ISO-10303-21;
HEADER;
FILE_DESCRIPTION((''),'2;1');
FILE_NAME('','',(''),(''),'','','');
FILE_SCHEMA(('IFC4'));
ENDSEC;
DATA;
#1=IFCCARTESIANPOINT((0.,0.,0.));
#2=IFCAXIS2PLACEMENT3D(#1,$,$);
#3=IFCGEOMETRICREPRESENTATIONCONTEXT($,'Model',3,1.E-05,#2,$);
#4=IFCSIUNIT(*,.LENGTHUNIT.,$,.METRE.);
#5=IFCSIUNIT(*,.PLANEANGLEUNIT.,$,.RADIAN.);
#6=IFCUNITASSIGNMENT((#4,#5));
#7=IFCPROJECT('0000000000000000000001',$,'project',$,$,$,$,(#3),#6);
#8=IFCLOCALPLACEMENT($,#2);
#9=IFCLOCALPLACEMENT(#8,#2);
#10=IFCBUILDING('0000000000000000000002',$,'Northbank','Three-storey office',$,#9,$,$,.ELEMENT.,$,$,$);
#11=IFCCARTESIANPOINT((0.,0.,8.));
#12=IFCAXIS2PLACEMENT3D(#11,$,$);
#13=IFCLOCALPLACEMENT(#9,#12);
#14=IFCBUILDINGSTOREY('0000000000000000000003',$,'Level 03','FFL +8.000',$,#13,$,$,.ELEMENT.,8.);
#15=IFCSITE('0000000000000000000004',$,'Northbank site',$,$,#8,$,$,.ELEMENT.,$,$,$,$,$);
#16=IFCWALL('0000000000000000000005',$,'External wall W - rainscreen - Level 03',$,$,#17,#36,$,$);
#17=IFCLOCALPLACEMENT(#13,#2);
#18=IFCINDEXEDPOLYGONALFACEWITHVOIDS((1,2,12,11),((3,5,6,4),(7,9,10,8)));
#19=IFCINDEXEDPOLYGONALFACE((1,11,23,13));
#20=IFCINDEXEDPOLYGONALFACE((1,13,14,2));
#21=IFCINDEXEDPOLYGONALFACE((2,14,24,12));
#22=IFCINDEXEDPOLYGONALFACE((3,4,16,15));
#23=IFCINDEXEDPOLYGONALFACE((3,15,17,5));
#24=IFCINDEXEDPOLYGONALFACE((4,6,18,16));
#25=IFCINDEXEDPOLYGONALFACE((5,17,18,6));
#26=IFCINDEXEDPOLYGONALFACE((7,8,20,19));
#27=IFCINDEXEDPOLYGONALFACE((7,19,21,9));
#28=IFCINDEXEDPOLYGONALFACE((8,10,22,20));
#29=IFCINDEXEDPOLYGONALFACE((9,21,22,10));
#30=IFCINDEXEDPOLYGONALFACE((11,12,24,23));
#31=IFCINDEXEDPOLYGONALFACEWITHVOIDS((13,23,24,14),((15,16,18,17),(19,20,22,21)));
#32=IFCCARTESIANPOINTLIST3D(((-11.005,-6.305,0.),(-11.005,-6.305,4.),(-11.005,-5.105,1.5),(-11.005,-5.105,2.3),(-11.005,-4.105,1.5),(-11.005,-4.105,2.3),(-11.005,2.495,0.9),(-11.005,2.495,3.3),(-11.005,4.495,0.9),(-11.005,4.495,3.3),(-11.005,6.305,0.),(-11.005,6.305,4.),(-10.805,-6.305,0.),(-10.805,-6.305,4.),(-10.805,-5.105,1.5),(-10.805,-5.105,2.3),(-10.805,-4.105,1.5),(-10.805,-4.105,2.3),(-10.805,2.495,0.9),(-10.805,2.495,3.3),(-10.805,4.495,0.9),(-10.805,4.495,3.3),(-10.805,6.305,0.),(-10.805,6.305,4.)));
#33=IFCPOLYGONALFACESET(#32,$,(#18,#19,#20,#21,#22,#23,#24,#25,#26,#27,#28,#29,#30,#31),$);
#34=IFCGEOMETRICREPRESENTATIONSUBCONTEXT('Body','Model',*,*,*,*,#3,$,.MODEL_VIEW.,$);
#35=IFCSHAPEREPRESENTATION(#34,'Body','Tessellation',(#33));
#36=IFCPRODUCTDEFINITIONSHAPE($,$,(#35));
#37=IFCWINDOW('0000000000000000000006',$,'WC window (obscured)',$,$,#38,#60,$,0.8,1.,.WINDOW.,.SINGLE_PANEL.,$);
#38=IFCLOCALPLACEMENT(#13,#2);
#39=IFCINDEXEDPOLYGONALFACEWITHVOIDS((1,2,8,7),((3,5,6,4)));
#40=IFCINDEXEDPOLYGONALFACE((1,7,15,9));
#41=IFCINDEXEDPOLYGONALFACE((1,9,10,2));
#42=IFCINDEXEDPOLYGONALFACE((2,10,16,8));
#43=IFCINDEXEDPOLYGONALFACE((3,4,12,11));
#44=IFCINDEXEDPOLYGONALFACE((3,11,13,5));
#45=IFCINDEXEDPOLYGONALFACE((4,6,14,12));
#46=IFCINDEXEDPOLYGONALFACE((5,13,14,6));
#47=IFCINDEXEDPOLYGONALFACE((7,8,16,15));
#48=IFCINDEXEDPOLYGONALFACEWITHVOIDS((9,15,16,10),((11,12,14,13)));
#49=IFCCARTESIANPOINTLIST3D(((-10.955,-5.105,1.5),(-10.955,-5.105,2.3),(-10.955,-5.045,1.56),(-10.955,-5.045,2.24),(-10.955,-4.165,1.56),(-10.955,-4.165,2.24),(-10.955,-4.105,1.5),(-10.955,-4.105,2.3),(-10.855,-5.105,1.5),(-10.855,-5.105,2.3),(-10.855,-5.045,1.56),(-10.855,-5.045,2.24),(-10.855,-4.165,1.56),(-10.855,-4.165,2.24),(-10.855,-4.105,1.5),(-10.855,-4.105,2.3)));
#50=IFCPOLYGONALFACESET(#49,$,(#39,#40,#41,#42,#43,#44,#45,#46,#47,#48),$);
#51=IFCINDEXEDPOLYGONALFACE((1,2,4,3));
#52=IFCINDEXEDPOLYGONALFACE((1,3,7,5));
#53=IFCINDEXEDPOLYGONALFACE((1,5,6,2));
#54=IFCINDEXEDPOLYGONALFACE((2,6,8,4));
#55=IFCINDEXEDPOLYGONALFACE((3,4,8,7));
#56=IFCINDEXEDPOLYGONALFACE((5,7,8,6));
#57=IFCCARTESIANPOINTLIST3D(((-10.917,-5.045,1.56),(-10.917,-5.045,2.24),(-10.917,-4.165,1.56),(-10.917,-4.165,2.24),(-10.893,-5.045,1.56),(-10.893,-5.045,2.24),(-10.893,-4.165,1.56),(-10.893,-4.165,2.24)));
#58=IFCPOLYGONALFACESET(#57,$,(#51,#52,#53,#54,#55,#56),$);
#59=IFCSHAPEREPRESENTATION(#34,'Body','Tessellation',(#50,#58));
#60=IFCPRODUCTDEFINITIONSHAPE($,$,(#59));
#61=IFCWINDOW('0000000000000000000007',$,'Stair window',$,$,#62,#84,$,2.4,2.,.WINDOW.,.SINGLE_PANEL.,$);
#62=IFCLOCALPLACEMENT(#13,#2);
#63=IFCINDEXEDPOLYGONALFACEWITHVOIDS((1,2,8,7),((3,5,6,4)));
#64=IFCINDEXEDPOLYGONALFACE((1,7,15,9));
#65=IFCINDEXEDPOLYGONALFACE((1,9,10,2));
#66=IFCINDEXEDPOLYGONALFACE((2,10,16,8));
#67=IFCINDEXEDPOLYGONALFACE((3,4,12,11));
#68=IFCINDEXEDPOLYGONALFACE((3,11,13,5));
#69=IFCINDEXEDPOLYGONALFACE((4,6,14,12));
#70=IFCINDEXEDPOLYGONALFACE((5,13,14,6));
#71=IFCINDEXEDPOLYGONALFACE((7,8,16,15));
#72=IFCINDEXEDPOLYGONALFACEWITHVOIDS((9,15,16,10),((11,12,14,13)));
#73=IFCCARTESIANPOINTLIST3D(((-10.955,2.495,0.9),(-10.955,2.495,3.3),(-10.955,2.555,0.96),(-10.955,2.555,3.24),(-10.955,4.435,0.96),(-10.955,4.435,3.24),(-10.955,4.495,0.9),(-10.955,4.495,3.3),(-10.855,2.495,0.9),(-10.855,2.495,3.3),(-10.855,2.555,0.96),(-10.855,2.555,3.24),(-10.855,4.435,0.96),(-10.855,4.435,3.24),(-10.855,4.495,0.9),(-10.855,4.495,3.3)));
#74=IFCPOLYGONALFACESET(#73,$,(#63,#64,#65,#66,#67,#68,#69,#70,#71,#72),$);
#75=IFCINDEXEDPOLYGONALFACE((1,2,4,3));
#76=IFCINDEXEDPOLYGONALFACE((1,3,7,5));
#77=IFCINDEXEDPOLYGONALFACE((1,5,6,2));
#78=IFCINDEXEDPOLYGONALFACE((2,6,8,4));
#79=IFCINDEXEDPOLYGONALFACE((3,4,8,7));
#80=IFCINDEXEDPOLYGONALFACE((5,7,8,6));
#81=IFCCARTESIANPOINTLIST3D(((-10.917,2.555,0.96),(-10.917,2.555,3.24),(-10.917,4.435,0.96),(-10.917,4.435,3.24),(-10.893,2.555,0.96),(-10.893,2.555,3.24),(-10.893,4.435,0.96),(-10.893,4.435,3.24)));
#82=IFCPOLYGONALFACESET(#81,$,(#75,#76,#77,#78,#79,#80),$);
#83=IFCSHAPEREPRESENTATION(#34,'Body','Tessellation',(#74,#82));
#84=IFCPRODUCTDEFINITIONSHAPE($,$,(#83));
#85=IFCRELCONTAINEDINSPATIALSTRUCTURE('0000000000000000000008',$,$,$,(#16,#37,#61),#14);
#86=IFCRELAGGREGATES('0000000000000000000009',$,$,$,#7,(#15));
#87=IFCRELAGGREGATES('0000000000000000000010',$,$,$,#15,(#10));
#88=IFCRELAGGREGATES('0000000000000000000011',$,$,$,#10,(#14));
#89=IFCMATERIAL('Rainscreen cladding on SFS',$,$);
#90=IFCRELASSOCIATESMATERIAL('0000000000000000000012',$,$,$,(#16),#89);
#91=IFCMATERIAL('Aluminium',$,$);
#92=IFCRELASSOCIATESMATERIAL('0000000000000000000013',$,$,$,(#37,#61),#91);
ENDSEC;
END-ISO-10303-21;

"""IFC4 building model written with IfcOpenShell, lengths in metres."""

from ifc_helpers import new_model, si_unit, frame, origin, place, context, subcontext, project, spatial, polyline, outline, extrude, material, element, fill, save


model = new_model("IFC4")

# Units and contexts
model_context = context("Model", 3, precision=1e-05, world=origin())
body_context = subcontext(model_context, "Body", "Model", "MODEL_VIEW")
ifc_project = project(units=[si_unit("LENGTHUNIT", "METRE"), si_unit("PLANEANGLEUNIT", "RADIAN")], contexts=[model_context])

# Site, building, storey
site_placement = place(None, origin())
site = spatial("IfcSite", under=ifc_project, at=site_placement, Name="Northbank site", CompositionType="ELEMENT")
building_placement = place(site_placement, origin())
building = spatial("IfcBuilding", under=site, at=building_placement, Name="Northbank", Description="Three-storey office", CompositionType="ELEMENT")
storey_placement = place(building_placement, frame((0.0, 0.0, 8.0)))
storey = spatial("IfcBuildingStorey", under=building, at=storey_placement, Name="Level 03", Description="FFL +8.000", CompositionType="ELEMENT", Elevation=8.0)

# Shared definitions
ifc_material_1 = material(Name="Aluminium")

# Wall, openings, windows
ifc_material_2 = material(Name="Rainscreen cladding on SFS")
wall_placement = place(storey_placement, frame((0.0, 0.0, -8.0)))
wall = element("IfcWall", 1, at=wall_placement, inside=storey, material=ifc_material_2, Name="External wall W - rainscreen - Level 03", context=body_context, shape_type="SweptSolid", body=[
    extrude(outline(polyline([(0.0, 0.0), (12.61, 0.0), (12.61, 4.0), (0.0, 4.0), (0.0, 0.0)]), holes=[polyline([(1.2, 1.5), (1.2, 2.3), (2.2, 2.3), (2.2, 1.5), (1.2, 1.5)]), polyline([(8.8, 0.9), (8.8, 3.3), (10.8, 3.3), (10.8, 0.9), (8.8, 0.9)])]), frame((-11.005, -6.305, 8.0), z_axis=(1.0, 0.0, 0.0), x_axis=(0.0, 1.0, 0.0)), (0.0, 0.0, 1.0), 0.2),
])
opening_1_placement = place(storey_placement, frame((0.0, 0.0, -8.0)))
opening_1 = element("IfcOpeningElement", 2, at=opening_1_placement, cuts=wall, PredefinedType="OPENING", context=body_context, shape_type="SweptSolid", body=[
    extrude(outline(polyline([(0.0, 0.0), (1.0, 0.0), (1.0, 0.8), (0.0, 0.8), (0.0, 0.0)])), frame((-11.055, -5.105, 9.5), z_axis=(1.0, 0.0, 0.0), x_axis=(0.0, 1.0, 0.0)), (0.0, 0.0, 1.0), 0.3),
])
opening_2_placement = place(storey_placement, frame((0.0, 0.0, -8.0)))
opening_2 = element("IfcOpeningElement", 3, at=opening_2_placement, cuts=wall, PredefinedType="OPENING", context=body_context, shape_type="SweptSolid", body=[
    extrude(outline(polyline([(0.0, 0.0), (2.0, 0.0), (2.0, 2.4), (0.0, 2.4), (0.0, 0.0)])), frame((-11.055, 2.495, 8.9), z_axis=(1.0, 0.0, 0.0), x_axis=(0.0, 1.0, 0.0)), (0.0, 0.0, 1.0), 0.3),
])
window_1_placement = place(storey_placement, frame((0.0, 0.0, -8.0)))
window_1 = element("IfcWindow", 4, at=window_1_placement, inside=storey, material=ifc_material_1, Name="WC window (obscured)", OverallHeight=0.8, OverallWidth=1.0, PartitioningType="SINGLE_PANEL", PredefinedType="WINDOW", context=body_context, shape_type="SweptSolid", body=[
    extrude(outline(polyline([(0.0, 0.0), (1.0, 0.0), (1.0, 0.8), (0.0, 0.8), (0.0, 0.0)]), holes=[polyline([(0.06, 0.06), (0.06, 0.74), (0.94, 0.74), (0.94, 0.06), (0.06, 0.06)])]), frame((-10.955, -5.105, 9.5), z_axis=(1.0, 0.0, 0.0), x_axis=(0.0, 1.0, 0.0)), (0.0, 0.0, 1.0), 0.1),
    extrude(outline(polyline([(0.0, 0.0), (0.88, 0.0), (0.88, 0.68), (0.0, 0.68), (0.0, 0.0)])), frame((-10.917, -5.045, 9.56), z_axis=(1.0, 0.0, 0.0), x_axis=(0.0, 1.0, 0.0)), (0.0, 0.0, 1.0), 0.024),
])
fill(opening_1, window_1)
window_2_placement = place(storey_placement, frame((0.0, 0.0, -8.0)))
window_2 = element("IfcWindow", 5, at=window_2_placement, inside=storey, material=ifc_material_1, Name="Stair window", OverallHeight=2.4, OverallWidth=2.0, PartitioningType="SINGLE_PANEL", PredefinedType="WINDOW", context=body_context, shape_type="SweptSolid", body=[
    extrude(outline(polyline([(0.0, 0.0), (2.0, 0.0), (2.0, 2.4), (0.0, 2.4), (0.0, 0.0)]), holes=[polyline([(0.06, 0.06), (0.06, 2.34), (1.94, 2.34), (1.94, 0.06), (0.06, 0.06)])]), frame((-10.955, 2.495, 8.9), z_axis=(1.0, 0.0, 0.0), x_axis=(0.0, 1.0, 0.0)), (0.0, 0.0, 1.0), 0.1),
    extrude(outline(polyline([(0.0, 0.0), (1.88, 0.0), (1.88, 2.28), (0.0, 2.28), (0.0, 0.0)])), frame((-10.917, 2.555, 8.96), z_axis=(1.0, 0.0, 0.0), x_axis=(0.0, 1.0, 0.0)), (0.0, 0.0, 1.0), 0.024),
])
fill(opening_2, window_2)

save(model, "model.ifc")
